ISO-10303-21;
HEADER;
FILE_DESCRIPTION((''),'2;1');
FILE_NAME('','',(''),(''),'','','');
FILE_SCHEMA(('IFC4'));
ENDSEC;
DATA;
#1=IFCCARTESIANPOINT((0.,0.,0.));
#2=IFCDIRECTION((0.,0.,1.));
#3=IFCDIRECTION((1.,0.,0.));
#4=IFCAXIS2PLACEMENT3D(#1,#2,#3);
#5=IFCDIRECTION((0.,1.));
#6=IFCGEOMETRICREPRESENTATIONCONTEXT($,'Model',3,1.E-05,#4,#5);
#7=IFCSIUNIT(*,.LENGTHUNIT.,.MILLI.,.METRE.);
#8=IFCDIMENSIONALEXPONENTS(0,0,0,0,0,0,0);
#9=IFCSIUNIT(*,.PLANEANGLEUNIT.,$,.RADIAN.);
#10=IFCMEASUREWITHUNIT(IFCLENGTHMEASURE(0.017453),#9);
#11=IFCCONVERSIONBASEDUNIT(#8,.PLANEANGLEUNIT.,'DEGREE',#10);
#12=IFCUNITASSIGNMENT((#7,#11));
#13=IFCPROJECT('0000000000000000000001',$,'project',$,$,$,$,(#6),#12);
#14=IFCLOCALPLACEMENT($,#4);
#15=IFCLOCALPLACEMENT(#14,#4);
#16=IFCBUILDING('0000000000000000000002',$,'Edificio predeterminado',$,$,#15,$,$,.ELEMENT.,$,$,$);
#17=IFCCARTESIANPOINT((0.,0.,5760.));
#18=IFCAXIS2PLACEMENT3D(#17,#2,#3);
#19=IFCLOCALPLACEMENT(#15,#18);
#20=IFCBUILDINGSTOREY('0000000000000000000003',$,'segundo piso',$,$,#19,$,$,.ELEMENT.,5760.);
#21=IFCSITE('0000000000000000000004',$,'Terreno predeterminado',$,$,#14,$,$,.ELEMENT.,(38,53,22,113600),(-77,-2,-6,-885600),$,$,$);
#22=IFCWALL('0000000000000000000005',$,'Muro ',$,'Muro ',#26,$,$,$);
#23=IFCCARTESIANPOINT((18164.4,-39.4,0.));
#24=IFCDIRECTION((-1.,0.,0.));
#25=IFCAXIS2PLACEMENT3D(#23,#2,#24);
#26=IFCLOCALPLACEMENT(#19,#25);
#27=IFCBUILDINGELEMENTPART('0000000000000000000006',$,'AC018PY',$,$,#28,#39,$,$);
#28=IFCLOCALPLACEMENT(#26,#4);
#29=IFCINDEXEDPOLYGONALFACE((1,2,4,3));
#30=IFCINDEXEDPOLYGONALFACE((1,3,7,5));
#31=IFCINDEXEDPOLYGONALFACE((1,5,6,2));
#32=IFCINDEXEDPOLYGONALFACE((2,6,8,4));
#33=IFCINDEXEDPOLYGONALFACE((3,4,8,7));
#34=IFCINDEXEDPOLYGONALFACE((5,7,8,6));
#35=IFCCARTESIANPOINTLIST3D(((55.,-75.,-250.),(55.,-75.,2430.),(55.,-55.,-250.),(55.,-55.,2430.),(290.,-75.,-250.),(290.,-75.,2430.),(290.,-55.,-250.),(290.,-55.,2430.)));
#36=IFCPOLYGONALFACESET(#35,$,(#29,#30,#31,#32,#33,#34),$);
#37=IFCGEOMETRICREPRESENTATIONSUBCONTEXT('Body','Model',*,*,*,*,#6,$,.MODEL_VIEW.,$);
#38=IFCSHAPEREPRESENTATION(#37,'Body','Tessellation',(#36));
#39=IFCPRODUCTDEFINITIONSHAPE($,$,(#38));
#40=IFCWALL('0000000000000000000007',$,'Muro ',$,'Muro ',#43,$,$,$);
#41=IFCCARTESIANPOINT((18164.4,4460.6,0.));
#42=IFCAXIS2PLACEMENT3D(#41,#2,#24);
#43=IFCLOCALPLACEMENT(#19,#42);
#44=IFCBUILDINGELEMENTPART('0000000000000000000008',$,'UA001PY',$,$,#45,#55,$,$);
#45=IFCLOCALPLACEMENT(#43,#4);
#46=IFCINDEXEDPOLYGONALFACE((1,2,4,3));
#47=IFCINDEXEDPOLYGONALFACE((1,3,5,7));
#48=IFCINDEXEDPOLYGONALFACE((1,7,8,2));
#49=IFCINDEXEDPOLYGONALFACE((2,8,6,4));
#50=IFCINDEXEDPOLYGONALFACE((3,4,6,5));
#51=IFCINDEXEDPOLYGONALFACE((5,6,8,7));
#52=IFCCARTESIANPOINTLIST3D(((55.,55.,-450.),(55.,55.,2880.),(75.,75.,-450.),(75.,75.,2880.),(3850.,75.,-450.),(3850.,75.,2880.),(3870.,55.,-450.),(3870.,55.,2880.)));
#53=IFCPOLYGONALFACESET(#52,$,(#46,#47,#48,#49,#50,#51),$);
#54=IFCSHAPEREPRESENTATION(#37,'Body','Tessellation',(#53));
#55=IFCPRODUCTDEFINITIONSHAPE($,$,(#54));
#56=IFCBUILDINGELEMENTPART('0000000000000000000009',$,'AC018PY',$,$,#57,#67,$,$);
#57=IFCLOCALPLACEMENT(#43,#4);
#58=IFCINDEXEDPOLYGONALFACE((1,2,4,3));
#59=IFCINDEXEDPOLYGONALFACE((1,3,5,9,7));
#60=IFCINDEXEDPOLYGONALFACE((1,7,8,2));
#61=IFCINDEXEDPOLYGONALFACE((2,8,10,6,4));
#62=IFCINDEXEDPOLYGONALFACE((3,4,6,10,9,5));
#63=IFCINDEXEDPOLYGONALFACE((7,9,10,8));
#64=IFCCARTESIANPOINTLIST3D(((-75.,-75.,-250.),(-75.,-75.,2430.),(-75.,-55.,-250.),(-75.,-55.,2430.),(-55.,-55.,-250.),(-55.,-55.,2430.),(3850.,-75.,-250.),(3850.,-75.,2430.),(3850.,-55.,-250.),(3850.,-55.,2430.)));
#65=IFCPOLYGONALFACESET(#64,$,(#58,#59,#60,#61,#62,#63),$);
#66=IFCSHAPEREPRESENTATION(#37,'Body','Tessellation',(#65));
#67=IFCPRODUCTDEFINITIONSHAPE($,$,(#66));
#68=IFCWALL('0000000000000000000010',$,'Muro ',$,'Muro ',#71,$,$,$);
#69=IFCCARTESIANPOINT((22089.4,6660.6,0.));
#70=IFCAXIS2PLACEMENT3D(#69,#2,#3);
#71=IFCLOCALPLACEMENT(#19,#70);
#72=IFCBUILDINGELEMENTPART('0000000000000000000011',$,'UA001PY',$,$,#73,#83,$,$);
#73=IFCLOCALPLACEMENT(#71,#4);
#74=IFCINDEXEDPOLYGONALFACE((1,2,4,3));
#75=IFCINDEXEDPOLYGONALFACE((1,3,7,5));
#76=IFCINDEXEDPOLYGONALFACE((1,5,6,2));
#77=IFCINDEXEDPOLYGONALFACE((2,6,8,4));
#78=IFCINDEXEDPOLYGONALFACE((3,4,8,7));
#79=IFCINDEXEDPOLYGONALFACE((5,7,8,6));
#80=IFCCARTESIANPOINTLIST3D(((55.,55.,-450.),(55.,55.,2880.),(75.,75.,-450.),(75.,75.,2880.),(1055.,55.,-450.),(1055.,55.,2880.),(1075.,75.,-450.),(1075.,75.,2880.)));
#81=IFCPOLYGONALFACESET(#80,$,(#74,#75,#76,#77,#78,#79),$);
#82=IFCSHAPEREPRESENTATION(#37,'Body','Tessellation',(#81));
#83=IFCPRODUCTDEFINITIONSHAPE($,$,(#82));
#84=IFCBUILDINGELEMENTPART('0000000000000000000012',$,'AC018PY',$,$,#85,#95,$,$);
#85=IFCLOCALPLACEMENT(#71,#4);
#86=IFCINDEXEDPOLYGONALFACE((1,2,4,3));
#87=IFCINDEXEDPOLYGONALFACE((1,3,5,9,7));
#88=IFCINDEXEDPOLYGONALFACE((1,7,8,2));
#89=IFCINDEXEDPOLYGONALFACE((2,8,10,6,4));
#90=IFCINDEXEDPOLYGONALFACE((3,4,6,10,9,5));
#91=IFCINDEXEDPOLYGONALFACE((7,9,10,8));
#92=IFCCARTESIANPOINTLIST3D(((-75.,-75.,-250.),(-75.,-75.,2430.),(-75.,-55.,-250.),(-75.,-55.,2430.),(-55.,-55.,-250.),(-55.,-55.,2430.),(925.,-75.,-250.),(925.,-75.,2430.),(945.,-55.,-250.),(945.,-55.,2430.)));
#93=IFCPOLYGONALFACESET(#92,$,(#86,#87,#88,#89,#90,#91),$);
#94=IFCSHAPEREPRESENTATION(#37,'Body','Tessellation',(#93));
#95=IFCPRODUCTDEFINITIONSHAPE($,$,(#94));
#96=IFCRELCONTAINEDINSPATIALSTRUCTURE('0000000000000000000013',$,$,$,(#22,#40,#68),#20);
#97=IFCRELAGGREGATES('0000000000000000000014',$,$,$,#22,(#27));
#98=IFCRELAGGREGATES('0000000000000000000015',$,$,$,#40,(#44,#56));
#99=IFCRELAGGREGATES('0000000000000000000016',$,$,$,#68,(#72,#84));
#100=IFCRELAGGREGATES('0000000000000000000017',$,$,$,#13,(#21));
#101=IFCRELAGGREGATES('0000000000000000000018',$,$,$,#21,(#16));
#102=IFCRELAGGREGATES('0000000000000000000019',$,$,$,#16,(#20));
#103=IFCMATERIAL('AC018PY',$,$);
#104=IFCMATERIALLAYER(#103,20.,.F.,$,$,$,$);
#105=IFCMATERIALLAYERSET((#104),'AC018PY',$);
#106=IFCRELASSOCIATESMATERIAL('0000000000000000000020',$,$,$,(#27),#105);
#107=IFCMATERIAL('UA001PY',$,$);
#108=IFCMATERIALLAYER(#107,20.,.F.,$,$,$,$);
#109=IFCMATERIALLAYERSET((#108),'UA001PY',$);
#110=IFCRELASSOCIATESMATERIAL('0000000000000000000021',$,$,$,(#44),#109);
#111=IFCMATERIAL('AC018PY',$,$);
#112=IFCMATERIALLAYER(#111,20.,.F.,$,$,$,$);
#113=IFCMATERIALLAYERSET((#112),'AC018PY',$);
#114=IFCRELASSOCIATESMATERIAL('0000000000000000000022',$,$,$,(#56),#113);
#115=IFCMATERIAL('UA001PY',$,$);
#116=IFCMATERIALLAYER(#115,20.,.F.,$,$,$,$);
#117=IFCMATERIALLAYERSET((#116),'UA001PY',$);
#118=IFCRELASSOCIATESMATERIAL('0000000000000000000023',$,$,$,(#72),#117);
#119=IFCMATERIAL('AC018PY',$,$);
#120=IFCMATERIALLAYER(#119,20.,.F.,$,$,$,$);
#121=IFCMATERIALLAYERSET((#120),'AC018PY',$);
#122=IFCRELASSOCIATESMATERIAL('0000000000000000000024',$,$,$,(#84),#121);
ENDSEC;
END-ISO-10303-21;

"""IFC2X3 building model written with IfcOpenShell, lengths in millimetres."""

from ifc_helpers import new_model, entity, si_unit, converted_unit, direction, frame, origin_with_axes, place, context, subcontext, project, spatial, polyline, outline, extrude, material, layer, layer_set, layer_usage, element, aggregate, save


model = new_model("IFC2X3")

# Units and contexts
model_context = context("Model", 3, precision=1e-05, world=origin_with_axes(), true_north=direction((0.0, 1.0)))
body_context = subcontext(model_context, "Body", "Model", "MODEL_VIEW")
ifc_project = project(units=[si_unit("LENGTHUNIT", "METRE", prefix="MILLI"), converted_unit("PLANEANGLEUNIT", "DEGREE", entity("IfcLengthMeasure", 0.017453), si_unit("PLANEANGLEUNIT", "RADIAN"), dimensions=[0, 0, 0, 0, 0, 0, 0])], contexts=[model_context])

# Site, building, storey
site_placement = place(None, origin_with_axes())
site = spatial("IfcSite", under=ifc_project, at=site_placement, Name="Terreno predeterminado", CompositionType="ELEMENT", RefLatitude=(38, 53, 22, 113600), RefLongitude=(-77, -2, -6, -885600))
building_placement = place(site_placement, origin_with_axes())
building = spatial("IfcBuilding", under=site, at=building_placement, Name="Edificio predeterminado", CompositionType="ELEMENT")
storey_placement = place(building_placement, frame((0.0, 0.0, 5760.0), z_axis=(0.0, 0.0, 1.0), x_axis=(1.0, 0.0, 0.0)))
storey = spatial("IfcBuildingStorey", under=building, at=storey_placement, Name="segundo piso", CompositionType="ELEMENT", Elevation=5760.0)

# Wall, building element part
wall_1_placement = place(storey_placement, frame((18164.4, -39.4, 0.0), z_axis=(0.0, 0.0, 1.0), x_axis=(-1.0, 0.0, 0.0)))
wall_1 = element("IfcWall", 1, at=wall_1_placement, inside=storey, Name="Muro ", ObjectType="Muro ")
ifc_material_1 = material(Name="AC018PY")
ifc_layer_1 = layer(ifc_material_1, 20.0, ventilated=False)
ifc_layer_set_1 = layer_set([ifc_layer_1], Name="AC018PY")
ifc_layer_usage_1 = layer_usage(ifc_layer_set_1, "AXIS2", "NEGATIVE", 55.0)
building_element_part_1_placement = place(wall_1_placement, origin_with_axes())
building_element_part_1 = element("IfcBuildingElementPart", 2, at=building_element_part_1_placement, material=ifc_layer_usage_1, Name="AC018PY", context=body_context, shape_type="SweptSolid", body=[
    extrude(outline(polyline([(290.0, -55.0), (290.0, -75.0), (55.0, -75.0), (55.0, -55.0), (290.0, -55.0)])), frame((0.0, 0.0, -250.0), z_axis=(0.0, 0.0, 1.0), x_axis=(1.0, 0.0, 0.0)), (0.0, 0.0, 1.0), 2680.0),
])
aggregate(wall_1, [building_element_part_1])

# Walls, building element parts
wall_2_placement = place(storey_placement, frame((18164.4, 4460.6, 0.0), z_axis=(0.0, 0.0, 1.0), x_axis=(-1.0, 0.0, 0.0)))
wall_2 = element("IfcWall", 3, at=wall_2_placement, inside=storey, Name="Muro ", ObjectType="Muro ")
ifc_material_2 = material(Name="UA001PY")
ifc_layer_2 = layer(ifc_material_2, 20.0, ventilated=False)
ifc_layer_set_2 = layer_set([ifc_layer_2], Name="UA001PY")
ifc_layer_usage_2 = layer_usage(ifc_layer_set_2, "AXIS2", "NEGATIVE", -75.0)
building_element_part_2_placement = place(wall_2_placement, origin_with_axes())
building_element_part_2 = element("IfcBuildingElementPart", 4, at=building_element_part_2_placement, material=ifc_layer_usage_2, Name="UA001PY", context=body_context, shape_type="SweptSolid", body=[
    extrude(outline(polyline([(3850.0, 75.0), (3870.0, 55.0), (55.0, 55.0), (75.0, 75.0), (3850.0, 75.0)])), frame((0.0, 0.0, -450.0), z_axis=(0.0, 0.0, 1.0), x_axis=(1.0, 0.0, 0.0)), (0.0, 0.0, 1.0), 3330.0),
])
ifc_material_3 = material(Name="AC018PY")
ifc_layer_3 = layer(ifc_material_3, 20.0, ventilated=False)
ifc_layer_set_3 = layer_set([ifc_layer_3], Name="AC018PY")
ifc_layer_usage_3 = layer_usage(ifc_layer_set_3, "AXIS2", "NEGATIVE", 55.0)
building_element_part_3_placement = place(wall_2_placement, origin_with_axes())
building_element_part_3 = element("IfcBuildingElementPart", 5, at=building_element_part_3_placement, material=ifc_layer_usage_3, Name="AC018PY", context=body_context, shape_type="SweptSolid", body=[
    extrude(outline(polyline([(3850.0, -55.0), (3850.0, -75.0), (-75.0, -75.0), (-75.0, -55.0), (-55.0, -55.0), (3850.0, -55.0)])), frame((0.0, 0.0, -250.0), z_axis=(0.0, 0.0, 1.0), x_axis=(1.0, 0.0, 0.0)), (0.0, 0.0, 1.0), 2680.0),
])
aggregate(wall_2, [building_element_part_2, building_element_part_3])
wall_3_placement = place(storey_placement, frame((22089.4, 6660.6, 0.0), z_axis=(0.0, 0.0, 1.0), x_axis=(1.0, 0.0, 0.0)))
wall_3 = element("IfcWall", 6, at=wall_3_placement, inside=storey, Name="Muro ", ObjectType="Muro ")
ifc_material_4 = material(Name="UA001PY")
ifc_layer_4 = layer(ifc_material_4, 20.0, ventilated=False)
ifc_layer_set_4 = layer_set([ifc_layer_4], Name="UA001PY")
ifc_layer_usage_4 = layer_usage(ifc_layer_set_4, "AXIS2", "NEGATIVE", -75.0)
building_element_part_4_placement = place(wall_3_placement, origin_with_axes())
building_element_part_4 = element("IfcBuildingElementPart", 7, at=building_element_part_4_placement, material=ifc_layer_usage_4, Name="UA001PY", context=body_context, shape_type="SweptSolid", body=[
    extrude(outline(polyline([(1075.0, 75.0), (1055.0, 55.0), (55.0, 55.0), (75.0, 75.0), (1075.0, 75.0)])), frame((0.0, 0.0, -450.0), z_axis=(0.0, 0.0, 1.0), x_axis=(1.0, 0.0, 0.0)), (0.0, 0.0, 1.0), 3330.0),
])
ifc_material_5 = material(Name="AC018PY")
ifc_layer_5 = layer(ifc_material_5, 20.0, ventilated=False)
ifc_layer_set_5 = layer_set([ifc_layer_5], Name="AC018PY")
ifc_layer_usage_5 = layer_usage(ifc_layer_set_5, "AXIS2", "NEGATIVE", 55.0)
building_element_part_5_placement = place(wall_3_placement, origin_with_axes())
building_element_part_5 = element("IfcBuildingElementPart", 8, at=building_element_part_5_placement, material=ifc_layer_usage_5, Name="AC018PY", context=body_context, shape_type="SweptSolid", body=[
    extrude(outline(polyline([(945.0, -55.0), (925.0, -75.0), (-75.0, -75.0), (-75.0, -55.0), (-55.0, -55.0), (945.0, -55.0)])), frame((0.0, 0.0, -250.0), z_axis=(0.0, 0.0, 1.0), x_axis=(1.0, 0.0, 0.0)), (0.0, 0.0, 1.0), 2680.0),
])
aggregate(wall_3, [building_element_part_4, building_element_part_5])

save(model, "model.ifc")
